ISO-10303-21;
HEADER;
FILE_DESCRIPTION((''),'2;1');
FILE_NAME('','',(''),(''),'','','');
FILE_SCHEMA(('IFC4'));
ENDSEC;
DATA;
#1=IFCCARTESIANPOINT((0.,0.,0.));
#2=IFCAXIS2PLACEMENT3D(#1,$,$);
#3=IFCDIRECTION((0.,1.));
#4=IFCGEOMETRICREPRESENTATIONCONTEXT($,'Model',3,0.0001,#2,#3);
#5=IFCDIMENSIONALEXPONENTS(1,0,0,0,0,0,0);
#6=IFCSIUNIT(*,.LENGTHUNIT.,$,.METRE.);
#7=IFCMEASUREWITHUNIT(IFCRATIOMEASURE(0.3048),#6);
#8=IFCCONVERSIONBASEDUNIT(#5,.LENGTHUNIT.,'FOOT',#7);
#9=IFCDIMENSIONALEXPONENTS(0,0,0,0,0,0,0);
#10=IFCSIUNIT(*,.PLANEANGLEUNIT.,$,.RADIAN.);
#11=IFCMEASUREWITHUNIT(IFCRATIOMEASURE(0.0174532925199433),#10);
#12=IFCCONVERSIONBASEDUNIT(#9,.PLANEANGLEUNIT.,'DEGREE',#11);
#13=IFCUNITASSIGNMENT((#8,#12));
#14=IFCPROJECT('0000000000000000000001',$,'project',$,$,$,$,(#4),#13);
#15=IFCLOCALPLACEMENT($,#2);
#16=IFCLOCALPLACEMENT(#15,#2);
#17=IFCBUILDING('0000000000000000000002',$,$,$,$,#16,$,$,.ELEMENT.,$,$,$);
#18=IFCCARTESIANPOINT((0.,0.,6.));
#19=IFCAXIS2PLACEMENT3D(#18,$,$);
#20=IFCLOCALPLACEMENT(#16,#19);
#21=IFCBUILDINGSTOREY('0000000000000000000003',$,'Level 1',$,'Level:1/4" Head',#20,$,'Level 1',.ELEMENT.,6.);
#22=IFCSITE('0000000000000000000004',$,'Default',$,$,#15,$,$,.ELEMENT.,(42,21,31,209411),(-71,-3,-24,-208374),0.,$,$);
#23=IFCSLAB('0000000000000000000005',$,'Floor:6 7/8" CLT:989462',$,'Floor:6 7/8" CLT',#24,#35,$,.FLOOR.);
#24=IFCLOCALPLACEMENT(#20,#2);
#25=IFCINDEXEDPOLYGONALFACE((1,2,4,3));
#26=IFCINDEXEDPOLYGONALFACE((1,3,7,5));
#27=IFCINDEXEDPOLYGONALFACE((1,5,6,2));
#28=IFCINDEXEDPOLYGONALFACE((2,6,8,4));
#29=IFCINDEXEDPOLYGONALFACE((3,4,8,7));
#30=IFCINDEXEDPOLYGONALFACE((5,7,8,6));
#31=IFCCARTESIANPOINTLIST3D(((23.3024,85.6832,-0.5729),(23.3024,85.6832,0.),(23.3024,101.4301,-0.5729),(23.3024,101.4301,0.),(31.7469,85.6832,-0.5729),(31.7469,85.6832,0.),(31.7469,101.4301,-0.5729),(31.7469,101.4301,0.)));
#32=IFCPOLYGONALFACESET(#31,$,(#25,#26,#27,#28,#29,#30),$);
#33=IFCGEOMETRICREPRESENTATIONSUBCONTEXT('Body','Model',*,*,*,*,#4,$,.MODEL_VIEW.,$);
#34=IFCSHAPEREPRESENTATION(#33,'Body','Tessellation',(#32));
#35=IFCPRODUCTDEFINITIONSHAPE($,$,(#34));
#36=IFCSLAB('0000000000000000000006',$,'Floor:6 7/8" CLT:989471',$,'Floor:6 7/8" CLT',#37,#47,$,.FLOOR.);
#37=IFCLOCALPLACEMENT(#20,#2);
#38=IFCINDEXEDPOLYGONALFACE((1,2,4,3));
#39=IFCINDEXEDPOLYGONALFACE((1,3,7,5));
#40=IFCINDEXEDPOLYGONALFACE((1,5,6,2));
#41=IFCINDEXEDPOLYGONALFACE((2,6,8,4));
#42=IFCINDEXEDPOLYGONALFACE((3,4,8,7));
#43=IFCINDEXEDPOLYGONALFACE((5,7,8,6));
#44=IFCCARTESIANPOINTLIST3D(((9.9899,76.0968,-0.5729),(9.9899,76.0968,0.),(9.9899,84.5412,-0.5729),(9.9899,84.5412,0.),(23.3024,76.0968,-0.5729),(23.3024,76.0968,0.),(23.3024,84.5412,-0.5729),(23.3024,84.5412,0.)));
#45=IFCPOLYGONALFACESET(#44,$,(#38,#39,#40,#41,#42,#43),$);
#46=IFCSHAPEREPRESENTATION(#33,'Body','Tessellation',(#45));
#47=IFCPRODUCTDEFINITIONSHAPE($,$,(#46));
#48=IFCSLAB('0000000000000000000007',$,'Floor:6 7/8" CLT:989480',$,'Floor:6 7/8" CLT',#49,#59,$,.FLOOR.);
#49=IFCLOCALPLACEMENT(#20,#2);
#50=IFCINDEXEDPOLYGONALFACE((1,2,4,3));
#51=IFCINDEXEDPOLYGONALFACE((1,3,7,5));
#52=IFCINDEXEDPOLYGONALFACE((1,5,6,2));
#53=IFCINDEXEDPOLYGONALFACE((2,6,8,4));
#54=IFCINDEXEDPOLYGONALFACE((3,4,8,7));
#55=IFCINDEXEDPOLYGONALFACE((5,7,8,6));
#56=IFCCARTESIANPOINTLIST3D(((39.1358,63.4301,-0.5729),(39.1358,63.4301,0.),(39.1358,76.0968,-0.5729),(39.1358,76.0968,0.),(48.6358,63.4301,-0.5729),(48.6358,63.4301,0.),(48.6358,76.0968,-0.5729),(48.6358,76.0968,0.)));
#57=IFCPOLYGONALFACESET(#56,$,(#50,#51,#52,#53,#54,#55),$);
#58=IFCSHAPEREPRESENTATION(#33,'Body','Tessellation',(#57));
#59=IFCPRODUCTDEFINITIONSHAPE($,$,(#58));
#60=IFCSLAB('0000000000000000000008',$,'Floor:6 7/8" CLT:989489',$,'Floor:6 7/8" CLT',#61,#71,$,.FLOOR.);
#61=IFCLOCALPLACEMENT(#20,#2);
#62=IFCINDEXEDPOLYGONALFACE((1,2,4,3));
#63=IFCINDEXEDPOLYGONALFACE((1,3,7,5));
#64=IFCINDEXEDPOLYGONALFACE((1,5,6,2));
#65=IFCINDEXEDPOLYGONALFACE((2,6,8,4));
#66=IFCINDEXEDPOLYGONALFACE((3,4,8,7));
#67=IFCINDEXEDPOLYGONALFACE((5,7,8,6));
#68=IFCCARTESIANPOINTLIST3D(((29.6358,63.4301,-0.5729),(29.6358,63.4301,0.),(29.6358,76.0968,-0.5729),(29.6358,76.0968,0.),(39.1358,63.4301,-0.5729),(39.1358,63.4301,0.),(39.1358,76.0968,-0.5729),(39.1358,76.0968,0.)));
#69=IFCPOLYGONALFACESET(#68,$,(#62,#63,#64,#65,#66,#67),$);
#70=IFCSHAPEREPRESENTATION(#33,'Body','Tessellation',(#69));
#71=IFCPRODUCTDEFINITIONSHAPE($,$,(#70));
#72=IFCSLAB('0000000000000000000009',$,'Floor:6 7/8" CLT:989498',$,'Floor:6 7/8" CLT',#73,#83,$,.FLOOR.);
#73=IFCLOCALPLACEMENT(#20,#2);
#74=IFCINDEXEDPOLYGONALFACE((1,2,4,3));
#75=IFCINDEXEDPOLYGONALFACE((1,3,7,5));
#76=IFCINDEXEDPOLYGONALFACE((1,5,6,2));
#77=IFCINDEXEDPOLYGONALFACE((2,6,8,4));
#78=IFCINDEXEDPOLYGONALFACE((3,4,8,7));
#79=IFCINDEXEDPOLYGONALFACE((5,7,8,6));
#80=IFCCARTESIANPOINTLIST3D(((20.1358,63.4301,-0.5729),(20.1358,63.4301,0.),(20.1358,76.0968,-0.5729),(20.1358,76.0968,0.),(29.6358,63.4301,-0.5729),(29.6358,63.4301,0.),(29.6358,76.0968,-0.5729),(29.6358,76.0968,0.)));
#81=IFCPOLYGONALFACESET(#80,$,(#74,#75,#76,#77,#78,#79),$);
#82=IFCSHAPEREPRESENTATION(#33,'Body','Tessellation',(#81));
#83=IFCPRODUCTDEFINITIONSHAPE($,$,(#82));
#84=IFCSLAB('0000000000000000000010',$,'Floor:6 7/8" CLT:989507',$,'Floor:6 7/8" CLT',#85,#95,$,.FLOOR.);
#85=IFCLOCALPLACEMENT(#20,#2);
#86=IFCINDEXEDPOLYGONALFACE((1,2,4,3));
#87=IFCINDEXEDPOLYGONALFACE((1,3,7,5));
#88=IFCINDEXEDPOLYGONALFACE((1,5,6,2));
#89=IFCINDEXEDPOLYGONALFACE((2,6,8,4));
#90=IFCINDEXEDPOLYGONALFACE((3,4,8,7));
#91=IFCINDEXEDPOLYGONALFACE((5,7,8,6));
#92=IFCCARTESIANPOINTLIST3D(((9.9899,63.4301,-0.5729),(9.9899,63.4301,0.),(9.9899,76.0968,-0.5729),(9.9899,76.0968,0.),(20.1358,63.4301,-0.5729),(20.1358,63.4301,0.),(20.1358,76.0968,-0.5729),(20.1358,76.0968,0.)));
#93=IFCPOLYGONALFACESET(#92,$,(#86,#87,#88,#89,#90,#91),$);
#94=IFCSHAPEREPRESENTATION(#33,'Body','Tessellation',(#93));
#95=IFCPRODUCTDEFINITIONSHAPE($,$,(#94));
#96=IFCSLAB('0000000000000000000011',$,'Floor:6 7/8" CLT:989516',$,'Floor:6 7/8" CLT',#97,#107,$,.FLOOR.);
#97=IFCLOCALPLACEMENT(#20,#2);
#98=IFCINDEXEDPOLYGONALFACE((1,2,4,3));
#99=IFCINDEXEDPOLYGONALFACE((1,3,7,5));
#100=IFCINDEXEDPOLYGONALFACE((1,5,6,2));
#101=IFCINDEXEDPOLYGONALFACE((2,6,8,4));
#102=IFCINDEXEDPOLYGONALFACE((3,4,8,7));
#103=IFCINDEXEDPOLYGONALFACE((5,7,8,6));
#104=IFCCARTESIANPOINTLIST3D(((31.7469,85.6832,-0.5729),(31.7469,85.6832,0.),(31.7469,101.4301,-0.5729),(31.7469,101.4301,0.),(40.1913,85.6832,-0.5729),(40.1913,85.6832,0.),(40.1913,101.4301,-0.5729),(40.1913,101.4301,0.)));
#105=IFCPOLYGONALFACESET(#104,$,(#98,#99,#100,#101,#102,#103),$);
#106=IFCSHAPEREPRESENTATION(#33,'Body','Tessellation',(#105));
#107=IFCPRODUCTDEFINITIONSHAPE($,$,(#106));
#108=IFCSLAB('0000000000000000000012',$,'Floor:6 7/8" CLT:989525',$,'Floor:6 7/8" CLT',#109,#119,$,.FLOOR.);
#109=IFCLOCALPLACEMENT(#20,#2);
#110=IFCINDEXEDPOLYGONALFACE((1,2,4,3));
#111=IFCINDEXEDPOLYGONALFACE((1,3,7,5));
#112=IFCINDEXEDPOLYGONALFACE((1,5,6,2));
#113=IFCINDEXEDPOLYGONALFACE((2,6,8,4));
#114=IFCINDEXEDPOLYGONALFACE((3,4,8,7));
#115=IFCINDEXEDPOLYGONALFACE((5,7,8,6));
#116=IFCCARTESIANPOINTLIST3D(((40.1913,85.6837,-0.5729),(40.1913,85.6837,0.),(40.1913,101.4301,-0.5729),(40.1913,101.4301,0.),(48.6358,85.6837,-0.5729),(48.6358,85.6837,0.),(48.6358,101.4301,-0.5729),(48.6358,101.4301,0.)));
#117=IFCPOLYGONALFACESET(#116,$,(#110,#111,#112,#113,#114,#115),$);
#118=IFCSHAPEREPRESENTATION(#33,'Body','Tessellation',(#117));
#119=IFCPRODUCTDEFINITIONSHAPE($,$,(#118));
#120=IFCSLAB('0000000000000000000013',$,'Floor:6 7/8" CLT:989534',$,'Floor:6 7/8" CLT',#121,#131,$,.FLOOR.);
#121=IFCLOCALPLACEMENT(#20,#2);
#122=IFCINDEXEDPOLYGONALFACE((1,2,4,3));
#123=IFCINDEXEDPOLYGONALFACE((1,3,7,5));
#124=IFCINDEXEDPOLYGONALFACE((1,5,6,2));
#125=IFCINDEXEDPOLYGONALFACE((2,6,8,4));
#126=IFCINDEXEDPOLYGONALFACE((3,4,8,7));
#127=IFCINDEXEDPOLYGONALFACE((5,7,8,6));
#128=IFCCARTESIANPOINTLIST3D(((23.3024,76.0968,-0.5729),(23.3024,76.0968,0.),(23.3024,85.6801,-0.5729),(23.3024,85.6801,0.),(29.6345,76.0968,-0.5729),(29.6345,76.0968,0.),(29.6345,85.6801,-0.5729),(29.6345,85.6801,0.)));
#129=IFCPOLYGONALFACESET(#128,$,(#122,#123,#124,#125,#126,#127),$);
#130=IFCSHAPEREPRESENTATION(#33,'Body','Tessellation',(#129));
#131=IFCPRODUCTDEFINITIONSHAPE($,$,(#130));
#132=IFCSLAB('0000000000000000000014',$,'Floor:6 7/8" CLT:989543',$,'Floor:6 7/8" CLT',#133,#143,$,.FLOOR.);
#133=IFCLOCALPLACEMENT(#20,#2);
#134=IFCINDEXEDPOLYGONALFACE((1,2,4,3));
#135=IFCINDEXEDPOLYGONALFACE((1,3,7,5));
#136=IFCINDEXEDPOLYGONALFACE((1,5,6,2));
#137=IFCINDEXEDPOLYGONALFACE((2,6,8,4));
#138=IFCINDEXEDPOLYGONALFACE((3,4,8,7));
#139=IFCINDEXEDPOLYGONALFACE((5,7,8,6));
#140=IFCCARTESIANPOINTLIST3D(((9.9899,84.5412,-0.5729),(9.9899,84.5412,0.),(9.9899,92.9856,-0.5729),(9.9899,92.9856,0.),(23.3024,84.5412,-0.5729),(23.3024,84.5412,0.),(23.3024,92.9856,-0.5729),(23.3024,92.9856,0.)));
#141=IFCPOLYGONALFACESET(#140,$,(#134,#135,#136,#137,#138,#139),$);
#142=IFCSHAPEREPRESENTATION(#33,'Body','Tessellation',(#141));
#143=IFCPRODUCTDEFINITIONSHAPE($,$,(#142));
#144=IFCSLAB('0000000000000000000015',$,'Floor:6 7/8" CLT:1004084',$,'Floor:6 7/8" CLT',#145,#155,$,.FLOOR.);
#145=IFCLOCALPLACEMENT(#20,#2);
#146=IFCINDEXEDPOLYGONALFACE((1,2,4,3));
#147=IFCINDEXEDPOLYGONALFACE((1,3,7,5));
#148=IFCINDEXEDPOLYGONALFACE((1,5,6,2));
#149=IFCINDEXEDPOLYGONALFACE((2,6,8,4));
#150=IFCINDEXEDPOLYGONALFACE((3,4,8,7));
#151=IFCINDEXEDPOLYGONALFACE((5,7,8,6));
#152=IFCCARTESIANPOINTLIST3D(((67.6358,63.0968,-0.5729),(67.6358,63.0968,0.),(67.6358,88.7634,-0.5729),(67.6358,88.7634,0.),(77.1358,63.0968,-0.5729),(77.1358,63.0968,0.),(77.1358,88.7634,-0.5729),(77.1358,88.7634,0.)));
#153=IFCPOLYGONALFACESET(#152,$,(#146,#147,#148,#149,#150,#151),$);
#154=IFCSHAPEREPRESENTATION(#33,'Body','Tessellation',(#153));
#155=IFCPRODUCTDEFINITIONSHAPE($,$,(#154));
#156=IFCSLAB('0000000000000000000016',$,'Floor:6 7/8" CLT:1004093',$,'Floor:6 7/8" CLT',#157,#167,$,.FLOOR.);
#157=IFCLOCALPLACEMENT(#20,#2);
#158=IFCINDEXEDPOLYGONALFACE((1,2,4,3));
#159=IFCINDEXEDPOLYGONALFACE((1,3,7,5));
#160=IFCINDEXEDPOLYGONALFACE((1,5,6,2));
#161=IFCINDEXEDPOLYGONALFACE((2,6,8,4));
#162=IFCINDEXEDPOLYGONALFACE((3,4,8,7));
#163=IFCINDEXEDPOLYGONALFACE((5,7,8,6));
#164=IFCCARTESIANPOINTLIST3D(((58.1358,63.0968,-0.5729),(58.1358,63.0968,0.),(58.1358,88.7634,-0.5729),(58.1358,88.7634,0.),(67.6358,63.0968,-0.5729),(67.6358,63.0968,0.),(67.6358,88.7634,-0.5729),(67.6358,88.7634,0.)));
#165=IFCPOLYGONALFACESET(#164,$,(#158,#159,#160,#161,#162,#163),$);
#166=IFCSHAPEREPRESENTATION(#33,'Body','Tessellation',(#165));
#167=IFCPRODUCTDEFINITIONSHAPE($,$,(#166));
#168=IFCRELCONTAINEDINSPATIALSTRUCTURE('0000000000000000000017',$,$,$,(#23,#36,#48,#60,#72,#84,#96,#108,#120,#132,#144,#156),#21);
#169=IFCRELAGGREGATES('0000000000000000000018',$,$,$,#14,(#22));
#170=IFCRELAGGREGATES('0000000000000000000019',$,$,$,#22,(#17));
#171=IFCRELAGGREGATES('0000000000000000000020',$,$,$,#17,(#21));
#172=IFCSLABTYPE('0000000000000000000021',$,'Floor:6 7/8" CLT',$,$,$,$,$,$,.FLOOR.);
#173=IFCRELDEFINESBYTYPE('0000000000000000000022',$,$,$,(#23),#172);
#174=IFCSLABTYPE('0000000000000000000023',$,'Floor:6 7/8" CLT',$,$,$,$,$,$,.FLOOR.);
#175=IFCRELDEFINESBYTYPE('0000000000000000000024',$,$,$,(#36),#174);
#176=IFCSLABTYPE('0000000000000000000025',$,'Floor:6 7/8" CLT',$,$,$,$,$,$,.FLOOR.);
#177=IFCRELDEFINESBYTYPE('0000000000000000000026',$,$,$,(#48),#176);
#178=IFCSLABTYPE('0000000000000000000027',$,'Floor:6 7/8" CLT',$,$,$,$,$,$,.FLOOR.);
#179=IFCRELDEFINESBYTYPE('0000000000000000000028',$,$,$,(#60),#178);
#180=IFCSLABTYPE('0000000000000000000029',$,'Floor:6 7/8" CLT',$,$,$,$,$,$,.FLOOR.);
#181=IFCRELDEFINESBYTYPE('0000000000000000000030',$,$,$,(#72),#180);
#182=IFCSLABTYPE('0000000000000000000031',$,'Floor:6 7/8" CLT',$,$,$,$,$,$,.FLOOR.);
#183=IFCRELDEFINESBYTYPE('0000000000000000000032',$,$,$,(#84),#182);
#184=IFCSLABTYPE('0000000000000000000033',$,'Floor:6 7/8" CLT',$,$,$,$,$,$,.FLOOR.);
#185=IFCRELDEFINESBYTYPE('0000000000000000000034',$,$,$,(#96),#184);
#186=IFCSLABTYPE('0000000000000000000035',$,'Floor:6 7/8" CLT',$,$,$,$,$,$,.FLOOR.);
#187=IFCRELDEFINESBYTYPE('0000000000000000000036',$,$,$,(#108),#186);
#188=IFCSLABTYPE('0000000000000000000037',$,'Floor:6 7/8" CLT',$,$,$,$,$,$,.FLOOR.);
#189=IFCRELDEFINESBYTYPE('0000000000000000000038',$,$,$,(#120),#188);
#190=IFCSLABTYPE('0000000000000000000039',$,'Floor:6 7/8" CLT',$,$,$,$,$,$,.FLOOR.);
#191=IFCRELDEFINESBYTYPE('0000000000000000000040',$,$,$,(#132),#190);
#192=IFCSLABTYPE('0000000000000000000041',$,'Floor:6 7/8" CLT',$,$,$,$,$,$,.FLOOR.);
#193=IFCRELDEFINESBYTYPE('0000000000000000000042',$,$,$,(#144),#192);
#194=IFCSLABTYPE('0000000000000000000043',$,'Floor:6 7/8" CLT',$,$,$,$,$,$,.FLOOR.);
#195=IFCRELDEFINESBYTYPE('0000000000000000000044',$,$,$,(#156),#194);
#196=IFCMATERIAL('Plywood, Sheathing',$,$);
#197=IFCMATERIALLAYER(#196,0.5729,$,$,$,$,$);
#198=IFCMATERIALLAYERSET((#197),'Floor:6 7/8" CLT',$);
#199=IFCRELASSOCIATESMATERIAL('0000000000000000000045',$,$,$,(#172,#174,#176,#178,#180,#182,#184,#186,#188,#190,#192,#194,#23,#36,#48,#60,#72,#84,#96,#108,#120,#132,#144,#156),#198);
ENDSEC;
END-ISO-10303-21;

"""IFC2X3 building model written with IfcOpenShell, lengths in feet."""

from ifc_helpers import new_model, entity, si_unit, converted_unit, direction, frame, frame_2d, origin, place, context, subcontext, project, spatial, rectangle, extrude, material, layer, layer_set, layer_usage, type_object, element, save


model = new_model("IFC2X3")

# Units and contexts
model_context = context("Model", 3, precision=0.0001, world=origin(), true_north=direction((0.0, 1.0)))
body_context = subcontext(model_context, "Body", "Model", "MODEL_VIEW")
ifc_project = project(units=[converted_unit("LENGTHUNIT", "FOOT", entity("IfcRatioMeasure", 0.3048), si_unit("LENGTHUNIT", "METRE"), dimensions=[1, 0, 0, 0, 0, 0, 0]), converted_unit("PLANEANGLEUNIT", "DEGREE", entity("IfcRatioMeasure", 0.0174532925199433), si_unit("PLANEANGLEUNIT", "RADIAN"), dimensions=[0, 0, 0, 0, 0, 0, 0])], contexts=[model_context])

# Site, building, storey
site_placement = place(None, origin())
site = spatial("IfcSite", under=ifc_project, at=site_placement, Name="Default", CompositionType="ELEMENT", RefLatitude=(42, 21, 31, 209411), RefLongitude=(-71, -3, -24, -208374), RefElevation=0.0)
building_placement = place(site_placement, origin())
building = spatial("IfcBuilding", under=site, at=building_placement, CompositionType="ELEMENT")
storey_placement = place(building_placement, frame((0.0, 0.0, 6.0)))
storey = spatial("IfcBuildingStorey", under=building, at=storey_placement, Name="Level 1", ObjectType="Level:1/4\" Head", LongName="Level 1", CompositionType="ELEMENT", Elevation=6.0)

# Slabs
ifc_material_1 = material(Name="Plywood, Sheathing")
ifc_layer = layer(ifc_material_1, 0.5729)
ifc_layer_set = layer_set([ifc_layer], Name="Floor:6 7/8\" CLT")
ifc_layer_usage_1 = layer_usage(ifc_layer_set, "AXIS3", "POSITIVE", 0.0)
slab_type_1 = type_object("IfcSlabType", Name="Floor:6 7/8\" CLT", PredefinedType="FLOOR", material=ifc_layer_set)
slab_1_placement = place(storey_placement, origin())
element("IfcSlab", 1, at=slab_1_placement, inside=storey, type_object=slab_type_1, material=ifc_layer_usage_1, Name="Floor:6 7/8\" CLT:989462", ObjectType="Floor:6 7/8\" CLT", PredefinedType="FLOOR", context=body_context, shape_type="SweptSolid", body=[
    extrude(rectangle(XDim=15.7469, YDim=8.4444, at=frame_2d((0.0, 0.0), x_axis=(1.0, 0.0))), frame((27.5247, 93.5566, 0.0), z_axis=(0.0, 0.0, -1.0), x_axis=(0.0, 1.0, 0.0)), (0.0, 0.0, 1.0), 0.5729),
])
ifc_layer_usage_2 = layer_usage(ifc_layer_set, "AXIS3", "POSITIVE", 0.0)
slab_type_2 = type_object("IfcSlabType", Name="Floor:6 7/8\" CLT", PredefinedType="FLOOR", material=ifc_layer_set)
slab_2_placement = place(storey_placement, origin())
element("IfcSlab", 2, at=slab_2_placement, inside=storey, type_object=slab_type_2, material=ifc_layer_usage_2, Name="Floor:6 7/8\" CLT:989471", ObjectType="Floor:6 7/8\" CLT", PredefinedType="FLOOR", context=body_context, shape_type="SweptSolid", body=[
    extrude(rectangle(XDim=8.4444, YDim=13.3125, at=frame_2d((0.0, 0.0), x_axis=(1.0, 0.0))), frame((16.6462, 80.319, 0.0), z_axis=(0.0, 0.0, -1.0), x_axis=(0.0, 1.0, 0.0)), (0.0, 0.0, 1.0), 0.5729),
])
ifc_layer_usage_3 = layer_usage(ifc_layer_set, "AXIS3", "POSITIVE", 0.0)
slab_type_3 = type_object("IfcSlabType", Name="Floor:6 7/8\" CLT", PredefinedType="FLOOR", material=ifc_layer_set)
slab_3_placement = place(storey_placement, origin())
element("IfcSlab", 3, at=slab_3_placement, inside=storey, type_object=slab_type_3, material=ifc_layer_usage_3, Name="Floor:6 7/8\" CLT:989480", ObjectType="Floor:6 7/8\" CLT", PredefinedType="FLOOR", context=body_context, shape_type="SweptSolid", body=[
    extrude(rectangle(XDim=12.6667, YDim=9.5, at=frame_2d((0.0, 0.0), x_axis=(1.0, 0.0))), frame((43.8858, 69.7634, 0.0), z_axis=(0.0, 0.0, -1.0), x_axis=(0.0, 1.0, 0.0)), (0.0, 0.0, 1.0), 0.5729),
])
ifc_layer_usage_4 = layer_usage(ifc_layer_set, "AXIS3", "POSITIVE", 0.0)
slab_type_4 = type_object("IfcSlabType", Name="Floor:6 7/8\" CLT", PredefinedType="FLOOR", material=ifc_layer_set)
slab_4_placement = place(storey_placement, origin())
element("IfcSlab", 4, at=slab_4_placement, inside=storey, type_object=slab_type_4, material=ifc_layer_usage_4, Name="Floor:6 7/8\" CLT:989489", ObjectType="Floor:6 7/8\" CLT", PredefinedType="FLOOR", context=body_context, shape_type="SweptSolid", body=[
    extrude(rectangle(XDim=12.6667, YDim=9.5, at=frame_2d((0.0, 0.0), x_axis=(1.0, 0.0))), frame((34.3858, 69.7634, 0.0), z_axis=(0.0, 0.0, -1.0), x_axis=(0.0, 1.0, 0.0)), (0.0, 0.0, 1.0), 0.5729),
])
ifc_layer_usage_5 = layer_usage(ifc_layer_set, "AXIS3", "POSITIVE", 0.0)
slab_type_5 = type_object("IfcSlabType", Name="Floor:6 7/8\" CLT", PredefinedType="FLOOR", material=ifc_layer_set)
slab_5_placement = place(storey_placement, origin())
element("IfcSlab", 5, at=slab_5_placement, inside=storey, type_object=slab_type_5, material=ifc_layer_usage_5, Name="Floor:6 7/8\" CLT:989498", ObjectType="Floor:6 7/8\" CLT", PredefinedType="FLOOR", context=body_context, shape_type="SweptSolid", body=[
    extrude(rectangle(XDim=12.6667, YDim=9.5, at=frame_2d((0.0, 0.0), x_axis=(1.0, 0.0))), frame((24.8858, 69.7634, 0.0), z_axis=(0.0, 0.0, -1.0), x_axis=(0.0, 1.0, 0.0)), (0.0, 0.0, 1.0), 0.5729),
])
ifc_layer_usage_6 = layer_usage(ifc_layer_set, "AXIS3", "POSITIVE", 0.0)
slab_type_6 = type_object("IfcSlabType", Name="Floor:6 7/8\" CLT", PredefinedType="FLOOR", material=ifc_layer_set)
slab_6_placement = place(storey_placement, origin())
element("IfcSlab", 6, at=slab_6_placement, inside=storey, type_object=slab_type_6, material=ifc_layer_usage_6, Name="Floor:6 7/8\" CLT:989507", ObjectType="Floor:6 7/8\" CLT", PredefinedType="FLOOR", context=body_context, shape_type="SweptSolid", body=[
    extrude(rectangle(XDim=12.6667, YDim=10.1458, at=frame_2d((0.0, 0.0), x_axis=(1.0, 0.0))), frame((15.0629, 69.7634, 0.0), z_axis=(0.0, 0.0, -1.0), x_axis=(0.0, 1.0, 0.0)), (0.0, 0.0, 1.0), 0.5729),
])
ifc_layer_usage_7 = layer_usage(ifc_layer_set, "AXIS3", "POSITIVE", 0.0)
slab_type_7 = type_object("IfcSlabType", Name="Floor:6 7/8\" CLT", PredefinedType="FLOOR", material=ifc_layer_set)
slab_7_placement = place(storey_placement, origin())
element("IfcSlab", 7, at=slab_7_placement, inside=storey, type_object=slab_type_7, material=ifc_layer_usage_7, Name="Floor:6 7/8\" CLT:989516", ObjectType="Floor:6 7/8\" CLT", PredefinedType="FLOOR", context=body_context, shape_type="SweptSolid", body=[
    extrude(rectangle(XDim=15.7469, YDim=8.4444, at=frame_2d((0.0, 0.0), x_axis=(1.0, 0.0))), frame((35.9691, 93.5566, 0.0), z_axis=(0.0, 0.0, -1.0), x_axis=(0.0, 1.0, 0.0)), (0.0, 0.0, 1.0), 0.5729),
])
ifc_layer_usage_8 = layer_usage(ifc_layer_set, "AXIS3", "POSITIVE", 0.0)
slab_type_8 = type_object("IfcSlabType", Name="Floor:6 7/8\" CLT", PredefinedType="FLOOR", material=ifc_layer_set)
slab_8_placement = place(storey_placement, origin())
element("IfcSlab", 8, at=slab_8_placement, inside=storey, type_object=slab_type_8, material=ifc_layer_usage_8, Name="Floor:6 7/8\" CLT:989525", ObjectType="Floor:6 7/8\" CLT", PredefinedType="FLOOR", context=body_context, shape_type="SweptSolid", body=[
    extrude(rectangle(XDim=15.7464, YDim=8.4444, at=frame_2d((0.0, 0.0), x_axis=(1.0, 0.0))), frame((44.4136, 93.5569, 0.0), z_axis=(0.0, 0.0, -1.0), x_axis=(0.0, 1.0, 0.0)), (0.0, 0.0, 1.0), 0.5729),
])
ifc_layer_usage_9 = layer_usage(ifc_layer_set, "AXIS3", "POSITIVE", 0.0)
slab_type_9 = type_object("IfcSlabType", Name="Floor:6 7/8\" CLT", PredefinedType="FLOOR", material=ifc_layer_set)
slab_9_placement = place(storey_placement, origin())
element("IfcSlab", 9, at=slab_9_placement, inside=storey, type_object=slab_type_9, material=ifc_layer_usage_9, Name="Floor:6 7/8\" CLT:989534", ObjectType="Floor:6 7/8\" CLT", PredefinedType="FLOOR", context=body_context, shape_type="SweptSolid", body=[
    extrude(rectangle(XDim=9.5833, YDim=6.3321, at=frame_2d((0.0, 0.0), x_axis=(1.0, 0.0))), frame((26.4685, 80.8884, 0.0), z_axis=(0.0, 0.0, -1.0), x_axis=(0.0, 1.0, 0.0)), (0.0, 0.0, 1.0), 0.5729),
])
ifc_layer_usage_10 = layer_usage(ifc_layer_set, "AXIS3", "POSITIVE", 0.0)
slab_type_10 = type_object("IfcSlabType", Name="Floor:6 7/8\" CLT", PredefinedType="FLOOR", material=ifc_layer_set)
slab_10_placement = place(storey_placement, origin())
element("IfcSlab", 10, at=slab_10_placement, inside=storey, type_object=slab_type_10, material=ifc_layer_usage_10, Name="Floor:6 7/8\" CLT:989543", ObjectType="Floor:6 7/8\" CLT", PredefinedType="FLOOR", context=body_context, shape_type="SweptSolid", body=[
    extrude(rectangle(XDim=8.4444, YDim=13.3125, at=frame_2d((0.0, 0.0), x_axis=(1.0, 0.0))), frame((16.6462, 88.7634, 0.0), z_axis=(0.0, 0.0, -1.0), x_axis=(0.0, 1.0, 0.0)), (0.0, 0.0, 1.0), 0.5729),
])
ifc_layer_usage_11 = layer_usage(ifc_layer_set, "AXIS3", "POSITIVE", 0.0)
slab_type_11 = type_object("IfcSlabType", Name="Floor:6 7/8\" CLT", PredefinedType="FLOOR", material=ifc_layer_set)
slab_11_placement = place(storey_placement, origin())
element("IfcSlab", 11, at=slab_11_placement, inside=storey, type_object=slab_type_11, material=ifc_layer_usage_11, Name="Floor:6 7/8\" CLT:1004084", ObjectType="Floor:6 7/8\" CLT", PredefinedType="FLOOR", context=body_context, shape_type="SweptSolid", body=[
    extrude(rectangle(XDim=25.6667, YDim=9.5, at=frame_2d((0.0, 0.0), x_axis=(1.0, 0.0))), frame((72.3858, 75.9301, 0.0), z_axis=(0.0, 0.0, -1.0), x_axis=(0.0, 1.0, 0.0)), (0.0, 0.0, 1.0), 0.5729),
])
ifc_layer_usage_12 = layer_usage(ifc_layer_set, "AXIS3", "POSITIVE", 0.0)
slab_type_12 = type_object("IfcSlabType", Name="Floor:6 7/8\" CLT", PredefinedType="FLOOR", material=ifc_layer_set)
slab_12_placement = place(storey_placement, origin())
element("IfcSlab", 12, at=slab_12_placement, inside=storey, type_object=slab_type_12, material=ifc_layer_usage_12, Name="Floor:6 7/8\" CLT:1004093", ObjectType="Floor:6 7/8\" CLT", PredefinedType="FLOOR", context=body_context, shape_type="SweptSolid", body=[
    extrude(rectangle(XDim=25.6667, YDim=9.5, at=frame_2d((0.0, 0.0), x_axis=(1.0, 0.0))), frame((62.8858, 75.9301, 0.0), z_axis=(0.0, 0.0, -1.0), x_axis=(0.0, 1.0, 0.0)), (0.0, 0.0, 1.0), 0.5729),
])

save(model, "model.ifc")
